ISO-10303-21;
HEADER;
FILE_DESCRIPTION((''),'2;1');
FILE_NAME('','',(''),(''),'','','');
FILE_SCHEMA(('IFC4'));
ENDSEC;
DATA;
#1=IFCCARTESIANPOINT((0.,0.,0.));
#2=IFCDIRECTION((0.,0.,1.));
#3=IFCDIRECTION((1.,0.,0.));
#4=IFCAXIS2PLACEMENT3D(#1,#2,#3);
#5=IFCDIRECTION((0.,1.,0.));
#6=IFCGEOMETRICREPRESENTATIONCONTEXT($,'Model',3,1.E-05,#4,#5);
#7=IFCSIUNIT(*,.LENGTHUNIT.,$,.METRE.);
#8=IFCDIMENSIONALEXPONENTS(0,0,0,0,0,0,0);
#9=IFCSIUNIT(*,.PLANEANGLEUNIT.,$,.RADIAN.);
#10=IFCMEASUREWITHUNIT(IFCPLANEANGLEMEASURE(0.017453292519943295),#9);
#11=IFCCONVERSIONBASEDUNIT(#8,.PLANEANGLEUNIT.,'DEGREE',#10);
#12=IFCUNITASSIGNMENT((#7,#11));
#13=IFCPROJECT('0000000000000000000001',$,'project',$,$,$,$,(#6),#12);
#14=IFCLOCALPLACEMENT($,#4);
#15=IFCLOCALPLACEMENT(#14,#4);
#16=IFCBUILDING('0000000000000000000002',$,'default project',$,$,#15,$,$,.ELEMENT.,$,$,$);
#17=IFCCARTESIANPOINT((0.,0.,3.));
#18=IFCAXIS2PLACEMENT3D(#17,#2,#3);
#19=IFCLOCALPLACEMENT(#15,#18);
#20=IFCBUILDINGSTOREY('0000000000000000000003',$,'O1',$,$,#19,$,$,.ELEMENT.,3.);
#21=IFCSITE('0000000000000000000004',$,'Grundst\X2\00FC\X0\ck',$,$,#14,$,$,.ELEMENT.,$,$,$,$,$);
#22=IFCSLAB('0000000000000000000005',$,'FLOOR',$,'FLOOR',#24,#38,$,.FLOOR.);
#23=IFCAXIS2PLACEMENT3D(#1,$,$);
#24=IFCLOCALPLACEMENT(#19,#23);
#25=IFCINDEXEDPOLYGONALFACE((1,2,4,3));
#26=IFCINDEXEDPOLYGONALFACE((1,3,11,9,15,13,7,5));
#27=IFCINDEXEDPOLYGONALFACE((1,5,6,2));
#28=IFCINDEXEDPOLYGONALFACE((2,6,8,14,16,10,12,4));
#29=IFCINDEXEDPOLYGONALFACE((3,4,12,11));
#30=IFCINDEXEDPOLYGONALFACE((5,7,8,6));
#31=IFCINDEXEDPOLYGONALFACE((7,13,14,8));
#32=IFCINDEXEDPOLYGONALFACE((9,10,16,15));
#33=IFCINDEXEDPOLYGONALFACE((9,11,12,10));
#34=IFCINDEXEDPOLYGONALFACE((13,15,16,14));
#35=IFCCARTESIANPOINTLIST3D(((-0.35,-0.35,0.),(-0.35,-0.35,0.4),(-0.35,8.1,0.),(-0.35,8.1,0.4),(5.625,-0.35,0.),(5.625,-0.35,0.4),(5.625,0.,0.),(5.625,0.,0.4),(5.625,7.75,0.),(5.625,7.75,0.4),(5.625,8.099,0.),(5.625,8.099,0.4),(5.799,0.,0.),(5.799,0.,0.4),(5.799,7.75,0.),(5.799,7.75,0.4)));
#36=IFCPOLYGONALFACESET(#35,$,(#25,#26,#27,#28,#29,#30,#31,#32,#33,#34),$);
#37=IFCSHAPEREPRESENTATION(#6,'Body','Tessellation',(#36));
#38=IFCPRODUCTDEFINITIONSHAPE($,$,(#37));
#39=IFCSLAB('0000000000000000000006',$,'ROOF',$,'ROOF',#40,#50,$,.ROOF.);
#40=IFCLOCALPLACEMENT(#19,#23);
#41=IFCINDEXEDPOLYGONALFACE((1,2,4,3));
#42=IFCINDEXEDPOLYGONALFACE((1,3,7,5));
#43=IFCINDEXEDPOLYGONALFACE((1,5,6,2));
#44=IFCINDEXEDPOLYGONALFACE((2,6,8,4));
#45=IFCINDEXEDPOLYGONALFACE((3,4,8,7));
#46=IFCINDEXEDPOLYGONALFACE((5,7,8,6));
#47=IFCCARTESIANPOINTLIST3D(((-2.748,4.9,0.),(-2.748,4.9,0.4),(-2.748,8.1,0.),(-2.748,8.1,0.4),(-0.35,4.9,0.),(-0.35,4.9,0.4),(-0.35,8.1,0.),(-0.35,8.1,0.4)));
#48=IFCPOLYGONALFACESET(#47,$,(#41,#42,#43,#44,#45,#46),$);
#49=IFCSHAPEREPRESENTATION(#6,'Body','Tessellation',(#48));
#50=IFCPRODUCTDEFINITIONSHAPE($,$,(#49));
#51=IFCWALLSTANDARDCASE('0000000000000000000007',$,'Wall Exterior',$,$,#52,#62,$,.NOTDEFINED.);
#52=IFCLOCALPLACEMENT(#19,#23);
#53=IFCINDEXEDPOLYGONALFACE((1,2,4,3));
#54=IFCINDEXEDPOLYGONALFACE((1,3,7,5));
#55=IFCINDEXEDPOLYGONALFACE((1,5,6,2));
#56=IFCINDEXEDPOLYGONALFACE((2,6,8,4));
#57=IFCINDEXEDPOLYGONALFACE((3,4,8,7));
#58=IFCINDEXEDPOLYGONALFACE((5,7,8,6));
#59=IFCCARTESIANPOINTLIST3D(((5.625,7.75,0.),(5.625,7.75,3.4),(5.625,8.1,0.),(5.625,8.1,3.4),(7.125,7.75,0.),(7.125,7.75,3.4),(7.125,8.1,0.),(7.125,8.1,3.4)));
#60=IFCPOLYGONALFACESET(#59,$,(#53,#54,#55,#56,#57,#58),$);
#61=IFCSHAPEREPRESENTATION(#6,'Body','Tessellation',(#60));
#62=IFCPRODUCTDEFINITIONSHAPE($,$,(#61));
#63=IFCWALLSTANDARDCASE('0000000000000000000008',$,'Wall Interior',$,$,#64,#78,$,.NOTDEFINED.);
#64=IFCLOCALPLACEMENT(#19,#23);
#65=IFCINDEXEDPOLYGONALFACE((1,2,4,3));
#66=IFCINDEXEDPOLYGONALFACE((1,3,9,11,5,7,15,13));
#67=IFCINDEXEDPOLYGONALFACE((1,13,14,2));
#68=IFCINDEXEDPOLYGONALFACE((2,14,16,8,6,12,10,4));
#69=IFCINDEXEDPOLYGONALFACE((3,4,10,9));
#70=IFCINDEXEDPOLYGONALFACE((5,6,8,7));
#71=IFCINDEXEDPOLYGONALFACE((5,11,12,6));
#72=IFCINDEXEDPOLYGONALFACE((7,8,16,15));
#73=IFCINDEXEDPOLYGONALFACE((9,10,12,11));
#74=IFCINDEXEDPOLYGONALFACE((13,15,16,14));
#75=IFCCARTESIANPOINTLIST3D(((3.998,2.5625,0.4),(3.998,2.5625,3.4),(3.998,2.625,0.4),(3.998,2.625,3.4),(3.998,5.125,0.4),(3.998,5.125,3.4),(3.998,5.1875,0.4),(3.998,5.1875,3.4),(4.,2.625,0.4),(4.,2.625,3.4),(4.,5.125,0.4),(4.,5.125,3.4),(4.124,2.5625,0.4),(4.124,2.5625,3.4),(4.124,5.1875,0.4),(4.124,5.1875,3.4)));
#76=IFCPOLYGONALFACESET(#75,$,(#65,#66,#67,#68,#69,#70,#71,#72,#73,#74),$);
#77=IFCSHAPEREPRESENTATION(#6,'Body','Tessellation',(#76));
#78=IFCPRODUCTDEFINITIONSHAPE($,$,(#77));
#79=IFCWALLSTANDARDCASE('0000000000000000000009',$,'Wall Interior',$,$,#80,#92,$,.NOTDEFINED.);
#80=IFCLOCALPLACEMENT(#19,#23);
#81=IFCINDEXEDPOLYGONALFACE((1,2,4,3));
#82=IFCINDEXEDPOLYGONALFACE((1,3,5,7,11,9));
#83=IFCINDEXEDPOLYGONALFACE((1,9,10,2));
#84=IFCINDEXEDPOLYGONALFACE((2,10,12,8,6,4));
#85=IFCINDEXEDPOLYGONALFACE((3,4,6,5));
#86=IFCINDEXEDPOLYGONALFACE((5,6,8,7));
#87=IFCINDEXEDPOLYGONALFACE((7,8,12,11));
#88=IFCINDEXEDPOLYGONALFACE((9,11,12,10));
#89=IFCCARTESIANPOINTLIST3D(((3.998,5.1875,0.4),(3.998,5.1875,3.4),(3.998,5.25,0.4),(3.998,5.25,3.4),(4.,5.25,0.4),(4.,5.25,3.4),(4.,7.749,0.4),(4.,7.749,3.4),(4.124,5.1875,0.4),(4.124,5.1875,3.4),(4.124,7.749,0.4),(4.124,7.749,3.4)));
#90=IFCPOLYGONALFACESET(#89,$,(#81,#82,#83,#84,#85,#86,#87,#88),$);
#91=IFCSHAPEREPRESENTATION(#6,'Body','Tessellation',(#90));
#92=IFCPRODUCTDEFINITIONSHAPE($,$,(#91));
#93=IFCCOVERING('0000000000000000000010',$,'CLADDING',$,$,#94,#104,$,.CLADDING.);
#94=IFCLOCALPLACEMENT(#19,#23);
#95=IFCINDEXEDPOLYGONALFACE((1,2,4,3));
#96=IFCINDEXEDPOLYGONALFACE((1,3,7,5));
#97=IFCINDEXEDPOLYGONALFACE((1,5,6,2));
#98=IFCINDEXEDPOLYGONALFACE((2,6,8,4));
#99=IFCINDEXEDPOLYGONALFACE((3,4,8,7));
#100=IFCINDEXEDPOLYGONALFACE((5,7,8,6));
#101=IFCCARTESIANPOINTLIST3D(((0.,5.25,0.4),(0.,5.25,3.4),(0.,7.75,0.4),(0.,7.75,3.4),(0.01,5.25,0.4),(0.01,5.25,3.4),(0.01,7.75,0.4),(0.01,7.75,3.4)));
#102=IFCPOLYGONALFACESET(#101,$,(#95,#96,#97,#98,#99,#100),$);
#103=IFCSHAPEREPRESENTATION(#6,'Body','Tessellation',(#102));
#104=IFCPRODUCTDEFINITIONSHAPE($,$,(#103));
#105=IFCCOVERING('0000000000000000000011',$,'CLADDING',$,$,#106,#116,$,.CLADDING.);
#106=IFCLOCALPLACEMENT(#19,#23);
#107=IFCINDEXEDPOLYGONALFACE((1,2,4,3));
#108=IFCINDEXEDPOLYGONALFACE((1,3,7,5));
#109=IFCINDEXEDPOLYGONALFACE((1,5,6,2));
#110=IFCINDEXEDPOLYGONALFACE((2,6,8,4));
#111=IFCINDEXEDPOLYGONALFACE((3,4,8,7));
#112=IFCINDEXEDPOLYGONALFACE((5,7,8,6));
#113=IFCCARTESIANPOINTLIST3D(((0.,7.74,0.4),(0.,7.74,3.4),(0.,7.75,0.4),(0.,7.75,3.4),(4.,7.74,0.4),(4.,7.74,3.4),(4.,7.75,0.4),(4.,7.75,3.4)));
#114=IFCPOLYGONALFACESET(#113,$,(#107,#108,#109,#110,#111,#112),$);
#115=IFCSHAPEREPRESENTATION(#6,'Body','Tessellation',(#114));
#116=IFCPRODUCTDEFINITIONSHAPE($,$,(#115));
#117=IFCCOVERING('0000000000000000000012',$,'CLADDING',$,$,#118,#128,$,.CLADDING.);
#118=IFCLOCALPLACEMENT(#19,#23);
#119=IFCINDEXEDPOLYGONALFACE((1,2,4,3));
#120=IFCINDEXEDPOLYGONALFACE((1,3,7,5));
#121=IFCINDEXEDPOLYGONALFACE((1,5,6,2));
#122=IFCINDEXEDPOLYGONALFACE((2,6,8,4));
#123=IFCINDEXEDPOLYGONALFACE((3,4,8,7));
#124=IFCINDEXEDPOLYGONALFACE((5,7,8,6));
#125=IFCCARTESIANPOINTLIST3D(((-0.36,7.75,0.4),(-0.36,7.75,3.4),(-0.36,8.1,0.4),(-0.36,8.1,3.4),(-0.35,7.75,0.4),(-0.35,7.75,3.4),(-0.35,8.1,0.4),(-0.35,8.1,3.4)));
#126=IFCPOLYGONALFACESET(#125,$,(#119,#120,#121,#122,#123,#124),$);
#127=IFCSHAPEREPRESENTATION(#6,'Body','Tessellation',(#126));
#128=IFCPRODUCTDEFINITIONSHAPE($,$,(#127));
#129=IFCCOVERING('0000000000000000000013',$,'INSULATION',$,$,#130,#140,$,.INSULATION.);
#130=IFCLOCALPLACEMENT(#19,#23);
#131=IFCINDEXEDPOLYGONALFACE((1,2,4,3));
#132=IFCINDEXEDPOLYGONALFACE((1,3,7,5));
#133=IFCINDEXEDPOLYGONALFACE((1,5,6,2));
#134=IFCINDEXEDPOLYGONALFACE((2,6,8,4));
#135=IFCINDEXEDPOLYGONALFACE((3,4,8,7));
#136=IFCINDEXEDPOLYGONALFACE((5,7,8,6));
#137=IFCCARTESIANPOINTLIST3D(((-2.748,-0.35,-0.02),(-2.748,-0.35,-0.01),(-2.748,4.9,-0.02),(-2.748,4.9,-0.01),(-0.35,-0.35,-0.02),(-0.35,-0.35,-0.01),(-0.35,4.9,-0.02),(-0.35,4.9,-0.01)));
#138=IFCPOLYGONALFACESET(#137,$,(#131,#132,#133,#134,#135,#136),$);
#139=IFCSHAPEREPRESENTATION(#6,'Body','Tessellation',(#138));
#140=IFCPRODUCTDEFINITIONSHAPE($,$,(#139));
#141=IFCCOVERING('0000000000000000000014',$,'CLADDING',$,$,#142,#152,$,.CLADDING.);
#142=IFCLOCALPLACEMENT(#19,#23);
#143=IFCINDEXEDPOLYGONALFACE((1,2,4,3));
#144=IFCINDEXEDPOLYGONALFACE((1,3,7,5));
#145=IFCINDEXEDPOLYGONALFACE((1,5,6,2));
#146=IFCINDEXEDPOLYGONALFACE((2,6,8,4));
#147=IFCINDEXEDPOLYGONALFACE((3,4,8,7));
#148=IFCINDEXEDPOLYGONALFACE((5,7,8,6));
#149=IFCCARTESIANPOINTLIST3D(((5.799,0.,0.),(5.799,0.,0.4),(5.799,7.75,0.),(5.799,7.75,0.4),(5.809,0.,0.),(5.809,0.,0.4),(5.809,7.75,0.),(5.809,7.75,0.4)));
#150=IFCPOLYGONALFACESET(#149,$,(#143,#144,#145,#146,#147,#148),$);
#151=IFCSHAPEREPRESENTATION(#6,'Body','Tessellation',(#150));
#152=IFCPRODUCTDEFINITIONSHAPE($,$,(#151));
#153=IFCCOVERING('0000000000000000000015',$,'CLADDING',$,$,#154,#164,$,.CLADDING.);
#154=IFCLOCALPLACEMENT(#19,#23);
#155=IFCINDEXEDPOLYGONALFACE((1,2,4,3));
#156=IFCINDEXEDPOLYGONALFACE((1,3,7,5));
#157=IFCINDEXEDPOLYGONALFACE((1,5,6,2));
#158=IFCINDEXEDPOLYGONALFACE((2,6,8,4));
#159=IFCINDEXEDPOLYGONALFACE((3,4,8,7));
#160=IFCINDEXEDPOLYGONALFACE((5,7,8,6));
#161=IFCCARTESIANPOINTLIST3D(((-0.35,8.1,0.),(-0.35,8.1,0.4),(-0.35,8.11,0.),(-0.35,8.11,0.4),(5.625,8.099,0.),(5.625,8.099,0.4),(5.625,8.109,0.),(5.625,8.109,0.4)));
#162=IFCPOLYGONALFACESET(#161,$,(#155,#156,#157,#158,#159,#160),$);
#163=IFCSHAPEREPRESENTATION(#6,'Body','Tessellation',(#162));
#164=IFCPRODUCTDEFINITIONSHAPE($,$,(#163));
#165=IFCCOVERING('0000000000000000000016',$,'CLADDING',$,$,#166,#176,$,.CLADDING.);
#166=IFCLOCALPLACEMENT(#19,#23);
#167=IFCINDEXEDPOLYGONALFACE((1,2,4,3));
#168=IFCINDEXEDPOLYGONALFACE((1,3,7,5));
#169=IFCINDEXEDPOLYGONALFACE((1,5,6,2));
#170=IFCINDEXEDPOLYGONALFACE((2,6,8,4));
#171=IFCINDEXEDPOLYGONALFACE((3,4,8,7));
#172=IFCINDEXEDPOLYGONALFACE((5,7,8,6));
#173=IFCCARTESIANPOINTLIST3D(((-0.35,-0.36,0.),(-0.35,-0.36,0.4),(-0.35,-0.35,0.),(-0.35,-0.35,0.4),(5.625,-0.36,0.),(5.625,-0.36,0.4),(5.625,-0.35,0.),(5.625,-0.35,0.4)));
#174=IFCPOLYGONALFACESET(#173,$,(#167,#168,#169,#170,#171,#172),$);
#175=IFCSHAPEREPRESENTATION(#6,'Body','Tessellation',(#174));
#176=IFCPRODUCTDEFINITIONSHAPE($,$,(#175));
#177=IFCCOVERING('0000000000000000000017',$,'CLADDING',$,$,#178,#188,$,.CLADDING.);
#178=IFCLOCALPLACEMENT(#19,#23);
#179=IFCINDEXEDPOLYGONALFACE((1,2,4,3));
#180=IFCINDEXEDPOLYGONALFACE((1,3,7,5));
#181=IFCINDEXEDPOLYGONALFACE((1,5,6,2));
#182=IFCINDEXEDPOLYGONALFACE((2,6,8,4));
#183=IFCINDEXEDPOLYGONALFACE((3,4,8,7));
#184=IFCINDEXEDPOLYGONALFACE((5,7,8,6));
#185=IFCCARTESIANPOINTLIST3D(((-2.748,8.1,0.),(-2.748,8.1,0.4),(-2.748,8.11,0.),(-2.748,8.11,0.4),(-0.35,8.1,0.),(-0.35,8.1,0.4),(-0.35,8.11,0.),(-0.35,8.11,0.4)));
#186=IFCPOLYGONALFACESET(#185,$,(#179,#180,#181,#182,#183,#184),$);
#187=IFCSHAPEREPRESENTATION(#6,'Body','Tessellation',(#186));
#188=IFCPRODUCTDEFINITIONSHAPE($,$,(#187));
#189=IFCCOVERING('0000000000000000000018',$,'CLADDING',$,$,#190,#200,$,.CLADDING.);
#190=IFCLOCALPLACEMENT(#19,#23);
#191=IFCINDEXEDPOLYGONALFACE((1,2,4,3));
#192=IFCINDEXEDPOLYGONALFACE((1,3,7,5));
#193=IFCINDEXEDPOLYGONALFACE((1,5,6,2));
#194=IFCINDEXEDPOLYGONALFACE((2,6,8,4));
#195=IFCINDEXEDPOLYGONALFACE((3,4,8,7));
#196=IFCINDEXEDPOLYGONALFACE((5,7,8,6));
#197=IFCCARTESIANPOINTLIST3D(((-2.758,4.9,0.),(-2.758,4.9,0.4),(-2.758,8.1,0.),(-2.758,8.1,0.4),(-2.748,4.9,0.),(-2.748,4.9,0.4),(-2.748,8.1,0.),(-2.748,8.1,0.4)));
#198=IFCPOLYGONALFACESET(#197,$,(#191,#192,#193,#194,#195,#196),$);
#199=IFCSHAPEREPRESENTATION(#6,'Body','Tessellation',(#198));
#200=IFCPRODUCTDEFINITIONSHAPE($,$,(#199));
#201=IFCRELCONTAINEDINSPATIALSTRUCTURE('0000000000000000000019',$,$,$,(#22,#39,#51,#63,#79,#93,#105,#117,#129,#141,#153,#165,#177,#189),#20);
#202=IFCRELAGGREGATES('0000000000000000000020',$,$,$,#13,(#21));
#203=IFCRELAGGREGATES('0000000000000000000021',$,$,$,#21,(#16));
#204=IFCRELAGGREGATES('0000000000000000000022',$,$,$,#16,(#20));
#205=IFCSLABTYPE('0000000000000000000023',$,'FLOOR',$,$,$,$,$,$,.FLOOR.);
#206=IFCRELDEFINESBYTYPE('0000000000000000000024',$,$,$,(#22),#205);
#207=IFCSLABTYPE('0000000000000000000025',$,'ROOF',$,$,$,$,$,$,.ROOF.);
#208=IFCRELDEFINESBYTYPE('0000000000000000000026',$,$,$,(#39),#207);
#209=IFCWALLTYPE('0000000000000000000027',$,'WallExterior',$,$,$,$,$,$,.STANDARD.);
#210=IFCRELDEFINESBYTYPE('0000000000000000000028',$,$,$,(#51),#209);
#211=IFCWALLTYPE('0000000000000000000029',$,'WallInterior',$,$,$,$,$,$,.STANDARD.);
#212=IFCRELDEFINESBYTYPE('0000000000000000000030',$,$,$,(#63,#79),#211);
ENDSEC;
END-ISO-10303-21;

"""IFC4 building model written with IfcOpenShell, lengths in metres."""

from ifc_helpers import new_model, entity, si_unit, converted_unit, direction, frame, origin_with_axes, place, context, project, spatial, polyline, outline, extrude, type_object, element, save


model = new_model("IFC4")

# Units and contexts
model_context = context("Model", 3, precision=1e-05, world=origin_with_axes(), true_north=direction((0.0, 1.0, 0.0)))
ifc_project = project(units=[si_unit("LENGTHUNIT", "METRE"), converted_unit("PLANEANGLEUNIT", "DEGREE", entity("IfcPlaneAngleMeasure", 0.017453292519943295), si_unit("PLANEANGLEUNIT", "RADIAN"), dimensions=[0, 0, 0, 0, 0, 0, 0])], contexts=[model_context])

# Site, building, storey
site_placement = place(None, origin_with_axes())
site = spatial("IfcSite", under=ifc_project, at=site_placement, Name="Grundstück", CompositionType="ELEMENT")
building_placement = place(site_placement, origin_with_axes())
building = spatial("IfcBuilding", under=site, at=building_placement, Name="default project", CompositionType="ELEMENT")
placement_1 = place(building_placement, frame((0.0, 0.0, 3.0), z_axis=(0.0, 0.0, 1.0), x_axis=(1.0, 0.0, 0.0)))
storey = spatial("IfcBuildingStorey", under=building, at=placement_1, Name="O1", CompositionType="ELEMENT", Elevation=3.0)

# Slabs
slab_type_1 = type_object("IfcSlabType", Name="FLOOR", PredefinedType="FLOOR")
slab_1_placement = place(placement_1, origin_with_axes())
element("IfcSlab", 1, at=slab_1_placement, inside=storey, type_object=slab_type_1, Name="FLOOR", ObjectType="FLOOR", PredefinedType="FLOOR", context=model_context, shape_type="SweptSolid", body=[
    extrude(outline(polyline([(5.625, 0.0), (5.799, 0.0), (5.799, 7.75), (5.625, 7.75), (5.625, 8.099), (-0.35, 8.1), (-0.35, -0.35), (5.625, -0.35), (5.625, 0.0)])), origin_with_axes(), (0.0, 0.0, 1.0), 0.4),
])
slab_type_2 = type_object("IfcSlabType", Name="ROOF", PredefinedType="ROOF")
slab_2_placement = place(placement_1, origin_with_axes())
element("IfcSlab", 2, at=slab_2_placement, inside=storey, type_object=slab_type_2, Name="ROOF", ObjectType="ROOF", PredefinedType="ROOF", context=model_context, shape_type="SweptSolid", body=[
    extrude(outline(polyline([(-0.35, 8.1), (-2.748, 8.1), (-2.748, 4.9), (-0.35, 4.9), (-0.35, 8.1)])), origin_with_axes(), (0.0, 0.0, 1.0), 0.4),
])

# Walls
wall_type_1 = type_object("IfcWallType", Name="WallExterior", PredefinedType="STANDARD")
placement_2 = place(placement_1, frame((5.625, 7.925, 0.0), z_axis=(0.0, 0.0, 1.0), x_axis=(1.0, 0.0, 0.0)))
element("IfcWallStandardCase", 3, at=placement_2, inside=storey, type_object=wall_type_1, Name="Wall Exterior", PredefinedType="NOTDEFINED", context=model_context, shape_type="SweptSolid", body=[
    extrude(outline(polyline([(1.5, 0.175), (0.0, 0.175), (0.0, -0.175), (1.5, -0.175), (1.5, 0.175)])), origin_with_axes(), (0.0, 0.0, 1.0), 3.4),
])
placement_3 = place(placement_1, frame((-0.175, 7.925, 0.4), z_axis=(0.0, 0.0, 1.0), x_axis=(1.0, -0.00006, 0.0)))
wall_type_2 = type_object("IfcWallType", Name="WallInterior", PredefinedType="STANDARD")
wall_1_placement = place(placement_1, frame((4.062, 2.5625, 0.4), z_axis=(0.0, 0.0, 1.0), x_axis=(0.0, 1.0, 0.0)))
element("IfcWallStandardCase", 4, at=wall_1_placement, inside=storey, type_object=wall_type_2, Name="Wall Interior", PredefinedType="NOTDEFINED", context=model_context, shape_type="SweptSolid", body=[
    extrude(outline(polyline([(2.5625, 0.062), (0.0625, 0.062), (0.0625, 0.064), (0.0, 0.064), (0.0, -0.062), (2.625, -0.062), (2.625, 0.064), (2.5625, 0.064), (2.5625, 0.062)])), origin_with_axes(), (0.0, 0.0, 1.0), 3.0),
])
wall_2_placement = place(placement_1, frame((4.062, 5.1875, 0.4), z_axis=(0.0, 0.0, 1.0), x_axis=(0.0, 1.0, 0.0)))
element("IfcWallStandardCase", 5, at=wall_2_placement, inside=storey, type_object=wall_type_2, Name="Wall Interior", PredefinedType="NOTDEFINED", context=model_context, shape_type="SweptSolid", body=[
    extrude(outline(polyline([(0.0625, 0.064), (0.0, 0.064), (0.0, -0.062), (2.5615, -0.062), (2.5615, 0.062), (0.0625, 0.062), (0.0625, 0.064)])), origin_with_axes(), (0.0, 0.0, 1.0), 3.0),
])

# Coverings
element("IfcCovering", 6, at=placement_1, inside=storey, Name="CLADDING", PredefinedType="CLADDING", context=model_context, shape_type="SweptSolid", body=[
    extrude(outline(polyline([(0.01, 5.25), (0.01, 7.75), (0.0, 7.75), (0.0, 5.25), (0.01, 5.25)])), frame((0.0, 0.0, 0.4), z_axis=(0.0, 0.0, 1.0), x_axis=(1.0, 0.0, 0.0)), (0.0, 0.0, 1.0), 3.0),
])
element("IfcCovering", 7, at=placement_1, inside=storey, Name="CLADDING", PredefinedType="CLADDING", context=model_context, shape_type="SweptSolid", body=[
    extrude(outline(polyline([(0.0, 7.74), (4.0, 7.74), (4.0, 7.75), (0.0, 7.75), (0.0, 7.74)])), frame((0.0, 0.0, 0.4), z_axis=(0.0, 0.0, 1.0), x_axis=(1.0, 0.0, 0.0)), (0.0, 0.0, 1.0), 3.0),
])
element("IfcCovering", 8, at=placement_3, inside=storey, Name="CLADDING", PredefinedType="CLADDING", context=model_context, shape_type="SweptSolid", body=[
    extrude(outline(polyline([(-0.185, 0.175), (-0.185, -0.175), (-0.175, -0.175), (-0.175, 0.175), (-0.185, 0.175)])), origin_with_axes(), (0.0, 0.0, 1.0), 3.0),
])
placement_4 = place(placement_1, origin_with_axes())
covering_1_placement = place(placement_4, frame((0.0, 0.0, -0.01), z_axis=(0.0, 0.0, 1.0), x_axis=(1.0, 0.0, 0.0)))
element("IfcCovering", 9, at=covering_1_placement, inside=storey, Name="INSULATION", PredefinedType="INSULATION", context=model_context, shape_type="SweptSolid", body=[
    extrude(outline(polyline([(-0.35, 4.9), (-2.748, 4.9), (-2.748, -0.35), (-0.35, -0.35), (-0.35, 4.9)])), frame((0.0, 0.0, -0.01), z_axis=(0.0, 0.0, 1.0), x_axis=(1.0, 0.0, 0.0)), (0.0, 0.0, 1.0), 0.01),
])
covering_2_placement = place(slab_1_placement, origin_with_axes())
element("IfcCovering", 10, at=covering_2_placement, inside=storey, Name="CLADDING", PredefinedType="CLADDING", context=model_context, shape_type="SweptSolid", body=[
    extrude(outline(polyline([(5.809, 0.0), (5.809, 7.75), (5.799, 7.75), (5.799, 0.0), (5.809, 0.0)])), origin_with_axes(), (0.0, 0.0, 1.0), 0.4),
])
covering_3_placement = place(slab_1_placement, origin_with_axes())
element("IfcCovering", 11, at=covering_3_placement, inside=storey, Name="CLADDING", PredefinedType="CLADDING", context=model_context, shape_type="SweptSolid", body=[
    extrude(outline(polyline([(5.625, 8.109), (-0.35, 8.11), (-0.35, 8.1), (5.625, 8.099), (5.625, 8.109)])), origin_with_axes(), (0.0, 0.0, 1.0), 0.4),
])
covering_4_placement = place(slab_1_placement, origin_with_axes())
element("IfcCovering", 12, at=covering_4_placement, inside=storey, Name="CLADDING", PredefinedType="CLADDING", context=model_context, shape_type="SweptSolid", body=[
    extrude(outline(polyline([(-0.35, -0.36), (5.625, -0.36), (5.625, -0.35), (-0.35, -0.35), (-0.35, -0.36)])), origin_with_axes(), (0.0, 0.0, 1.0), 0.4),
])
covering_5_placement = place(slab_2_placement, origin_with_axes())
element("IfcCovering", 13, at=covering_5_placement, inside=storey, Name="CLADDING", PredefinedType="CLADDING", context=model_context, shape_type="SweptSolid", body=[
    extrude(outline(polyline([(-0.35, 8.11), (-2.748, 8.11), (-2.748, 8.1), (-0.35, 8.1), (-0.35, 8.11)])), origin_with_axes(), (0.0, 0.0, 1.0), 0.4),
])
covering_6_placement = place(slab_2_placement, origin_with_axes())
element("IfcCovering", 14, at=covering_6_placement, inside=storey, Name="CLADDING", PredefinedType="CLADDING", context=model_context, shape_type="SweptSolid", body=[
    extrude(outline(polyline([(-2.758, 8.1), (-2.758, 4.9), (-2.748, 4.9), (-2.748, 8.1), (-2.758, 8.1)])), origin_with_axes(), (0.0, 0.0, 1.0), 0.4),
])

save(model, "model.ifc")
